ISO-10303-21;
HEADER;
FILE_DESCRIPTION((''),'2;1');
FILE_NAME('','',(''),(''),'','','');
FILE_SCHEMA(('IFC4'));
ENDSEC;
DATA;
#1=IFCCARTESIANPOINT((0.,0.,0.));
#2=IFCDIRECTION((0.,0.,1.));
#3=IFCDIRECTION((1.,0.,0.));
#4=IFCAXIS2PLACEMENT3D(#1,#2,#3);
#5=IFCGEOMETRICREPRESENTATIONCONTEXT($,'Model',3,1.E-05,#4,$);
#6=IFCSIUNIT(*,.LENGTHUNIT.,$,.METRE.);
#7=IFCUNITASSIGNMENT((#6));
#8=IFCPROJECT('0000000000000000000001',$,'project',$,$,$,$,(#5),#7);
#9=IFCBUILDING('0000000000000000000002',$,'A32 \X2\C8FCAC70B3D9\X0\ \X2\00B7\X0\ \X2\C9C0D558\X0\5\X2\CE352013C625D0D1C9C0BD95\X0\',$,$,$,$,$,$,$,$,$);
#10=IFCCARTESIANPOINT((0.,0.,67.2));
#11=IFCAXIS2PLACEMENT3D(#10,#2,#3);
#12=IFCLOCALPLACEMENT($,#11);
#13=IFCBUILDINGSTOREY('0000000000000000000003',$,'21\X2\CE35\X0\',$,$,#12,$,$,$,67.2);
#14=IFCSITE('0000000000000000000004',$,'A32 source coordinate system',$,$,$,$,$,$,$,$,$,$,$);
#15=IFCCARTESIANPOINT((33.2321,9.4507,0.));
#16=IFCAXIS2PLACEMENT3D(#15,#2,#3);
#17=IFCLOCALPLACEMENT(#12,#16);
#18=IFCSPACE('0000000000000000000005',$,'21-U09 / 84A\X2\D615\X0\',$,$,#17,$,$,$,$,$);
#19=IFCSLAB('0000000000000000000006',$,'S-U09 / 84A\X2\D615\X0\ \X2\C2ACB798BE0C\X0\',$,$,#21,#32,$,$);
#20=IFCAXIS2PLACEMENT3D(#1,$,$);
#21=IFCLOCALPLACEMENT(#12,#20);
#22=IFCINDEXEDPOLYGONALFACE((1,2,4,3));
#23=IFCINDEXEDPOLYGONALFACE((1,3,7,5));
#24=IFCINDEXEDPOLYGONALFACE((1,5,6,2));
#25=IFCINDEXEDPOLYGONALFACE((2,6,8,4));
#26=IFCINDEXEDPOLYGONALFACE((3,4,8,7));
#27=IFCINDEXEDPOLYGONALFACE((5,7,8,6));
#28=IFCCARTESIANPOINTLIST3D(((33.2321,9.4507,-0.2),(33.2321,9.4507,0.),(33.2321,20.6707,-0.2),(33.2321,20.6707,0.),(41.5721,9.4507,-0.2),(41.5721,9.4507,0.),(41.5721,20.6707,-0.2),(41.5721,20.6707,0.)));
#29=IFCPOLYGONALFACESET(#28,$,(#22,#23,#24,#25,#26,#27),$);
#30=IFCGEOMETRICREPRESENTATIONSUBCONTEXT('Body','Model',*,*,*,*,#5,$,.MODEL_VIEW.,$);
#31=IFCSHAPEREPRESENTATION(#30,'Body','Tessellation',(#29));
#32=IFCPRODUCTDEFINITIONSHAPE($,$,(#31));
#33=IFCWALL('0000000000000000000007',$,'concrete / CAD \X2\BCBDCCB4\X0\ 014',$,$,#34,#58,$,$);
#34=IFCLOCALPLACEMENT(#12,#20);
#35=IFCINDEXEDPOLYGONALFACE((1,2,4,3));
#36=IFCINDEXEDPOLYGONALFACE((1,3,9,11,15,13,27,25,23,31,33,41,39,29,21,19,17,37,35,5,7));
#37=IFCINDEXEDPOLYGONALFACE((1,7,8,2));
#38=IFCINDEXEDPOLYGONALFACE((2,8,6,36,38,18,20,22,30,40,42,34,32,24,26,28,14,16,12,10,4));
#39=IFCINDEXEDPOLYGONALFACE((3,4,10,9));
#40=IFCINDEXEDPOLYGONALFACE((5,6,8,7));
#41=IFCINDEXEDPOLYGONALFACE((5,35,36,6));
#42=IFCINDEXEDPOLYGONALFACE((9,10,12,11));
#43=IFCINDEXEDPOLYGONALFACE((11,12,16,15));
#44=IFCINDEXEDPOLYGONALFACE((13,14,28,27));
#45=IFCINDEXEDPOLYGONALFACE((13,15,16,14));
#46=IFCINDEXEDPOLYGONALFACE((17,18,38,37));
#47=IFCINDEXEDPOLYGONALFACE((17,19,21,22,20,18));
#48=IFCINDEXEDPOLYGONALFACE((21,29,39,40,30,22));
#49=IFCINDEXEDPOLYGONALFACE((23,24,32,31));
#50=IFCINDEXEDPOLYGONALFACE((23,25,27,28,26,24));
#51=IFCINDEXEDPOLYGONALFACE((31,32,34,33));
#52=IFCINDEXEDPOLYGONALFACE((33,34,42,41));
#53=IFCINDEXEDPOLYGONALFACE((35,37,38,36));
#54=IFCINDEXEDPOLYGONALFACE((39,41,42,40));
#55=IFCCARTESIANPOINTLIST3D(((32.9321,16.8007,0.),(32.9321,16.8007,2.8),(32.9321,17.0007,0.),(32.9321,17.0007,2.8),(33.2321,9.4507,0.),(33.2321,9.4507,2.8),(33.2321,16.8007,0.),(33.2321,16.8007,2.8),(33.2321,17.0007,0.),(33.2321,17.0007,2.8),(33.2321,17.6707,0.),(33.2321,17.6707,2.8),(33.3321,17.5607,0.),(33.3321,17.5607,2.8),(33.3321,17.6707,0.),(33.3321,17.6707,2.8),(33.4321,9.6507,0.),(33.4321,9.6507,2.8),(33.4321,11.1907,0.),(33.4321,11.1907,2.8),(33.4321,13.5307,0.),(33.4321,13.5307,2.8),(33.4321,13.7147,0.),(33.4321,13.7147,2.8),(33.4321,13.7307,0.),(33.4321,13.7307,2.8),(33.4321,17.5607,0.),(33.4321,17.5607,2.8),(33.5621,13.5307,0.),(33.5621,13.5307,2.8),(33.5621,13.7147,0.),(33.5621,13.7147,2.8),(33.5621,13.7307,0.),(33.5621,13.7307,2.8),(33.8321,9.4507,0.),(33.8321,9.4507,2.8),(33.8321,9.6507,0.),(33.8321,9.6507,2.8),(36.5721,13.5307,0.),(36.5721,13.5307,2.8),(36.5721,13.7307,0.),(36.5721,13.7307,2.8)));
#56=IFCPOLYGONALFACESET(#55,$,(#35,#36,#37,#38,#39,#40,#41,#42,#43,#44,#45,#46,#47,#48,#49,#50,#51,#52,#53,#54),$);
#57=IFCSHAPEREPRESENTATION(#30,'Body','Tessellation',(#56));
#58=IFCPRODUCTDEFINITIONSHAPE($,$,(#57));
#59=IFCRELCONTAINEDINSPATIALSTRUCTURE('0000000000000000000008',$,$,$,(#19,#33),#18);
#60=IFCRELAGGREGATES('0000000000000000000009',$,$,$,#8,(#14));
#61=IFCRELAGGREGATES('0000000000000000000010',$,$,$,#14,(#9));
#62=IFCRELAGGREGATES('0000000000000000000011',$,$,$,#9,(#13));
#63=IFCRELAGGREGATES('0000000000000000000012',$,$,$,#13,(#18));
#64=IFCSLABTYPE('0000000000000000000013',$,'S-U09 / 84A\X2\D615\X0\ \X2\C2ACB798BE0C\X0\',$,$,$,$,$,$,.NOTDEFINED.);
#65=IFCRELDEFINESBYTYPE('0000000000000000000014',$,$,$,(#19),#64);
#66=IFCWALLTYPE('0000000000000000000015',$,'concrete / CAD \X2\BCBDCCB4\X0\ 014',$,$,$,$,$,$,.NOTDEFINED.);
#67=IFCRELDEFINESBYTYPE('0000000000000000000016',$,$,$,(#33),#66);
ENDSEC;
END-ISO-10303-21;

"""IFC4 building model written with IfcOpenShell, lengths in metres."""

from ifc_helpers import new_model, si_unit, frame, origin, origin_with_axes, place, context, subcontext, project, spatial, polyline, outline, extrude, source, transform, mapped, type_object, type_shapes, element, save


model = new_model("IFC4")

# Units and contexts
model_context = context("Model", 3, precision=1e-05, world=origin_with_axes())
body_context = subcontext(model_context, "Body", "Model", "MODEL_VIEW")
ifc_project = project(units=[si_unit("LENGTHUNIT", "METRE")], contexts=[model_context])

# Site, building, storey, space
storey_placement = place(None, frame((0.0, 0.0, 67.2), z_axis=(0.0, 0.0, 1.0), x_axis=(1.0, 0.0, 0.0)))
space_placement = place(storey_placement, frame((33.2321, 9.4507, 0.0), z_axis=(0.0, 0.0, 1.0), x_axis=(1.0, 0.0, 0.0)))
site = spatial("IfcSite", under=ifc_project, Name="A32 source coordinate system")
building = spatial("IfcBuilding", under=site, Name="A32 주거동 · 지하5층–옥탑지붕")
storey = spatial("IfcBuildingStorey", under=building, at=storey_placement, Name="21층", Elevation=67.2)
space = spatial("IfcSpace", under=storey, at=space_placement, Name="21-U09 / 84A형")

# Slab
slab_type_1 = type_object("IfcSlabType", Name="S-U09 / 84A형 슬래브", PredefinedType="NOTDEFINED")
shared_shape_1 = source(origin(), body_context, "Body", "SweptSolid", [
    extrude(outline(polyline([(0.0, 11.22), (8.34, 11.22), (8.34, 0.0), (0.0, 0.0), (0.0, 11.22)])), frame((0.0, 0.0, -0.2)), (0.0, 0.0, 1.0), 0.2),
])
type_shapes(slab_type_1, [shared_shape_1])
slab_1_placement = place(space_placement, origin_with_axes())
element("IfcSlab", 1, at=slab_1_placement, inside=space, type_object=slab_type_1, Name="S-U09 / 84A형 슬래브", context=body_context, shape_type="MappedRepresentation", body=[
    mapped(shared_shape_1, transform((0.0, 0.0, 0.0), scale=1.0)),
])

# Wall
wall_type_1 = type_object("IfcWallType", Name="concrete / CAD 벽체 014", PredefinedType="NOTDEFINED")
shared_shape_2 = source(origin(), body_context, "Body", "SweptSolid", [
    extrude(outline(polyline([(3.34, 4.08), (0.33, 4.08), (0.2, 4.08), (0.2, 1.74), (0.2, 0.2), (0.6, 0.2), (0.6, 0.0), (0.0, 0.0), (0.0, 7.35), (-0.3, 7.35), (-0.3, 7.55), (0.0, 7.55), (0.0, 8.22), (0.1, 8.22), (0.1, 8.11), (0.2, 8.11), (0.2, 4.28), (0.2, 4.264), (0.33, 4.264), (0.33, 4.28), (3.34, 4.28), (3.34, 4.08)])), origin(), (0.0, 0.0, 1.0), 2.8),
])
type_shapes(wall_type_1, [shared_shape_2])
wall_1_placement = place(space_placement, origin_with_axes())
element("IfcWall", 2, at=wall_1_placement, inside=space, type_object=wall_type_1, Name="concrete / CAD 벽체 014", context=body_context, shape_type="MappedRepresentation", body=[
    mapped(shared_shape_2, transform((0.0, 0.0, 0.0), scale=1.0)),
])

save(model, "model.ifc")
